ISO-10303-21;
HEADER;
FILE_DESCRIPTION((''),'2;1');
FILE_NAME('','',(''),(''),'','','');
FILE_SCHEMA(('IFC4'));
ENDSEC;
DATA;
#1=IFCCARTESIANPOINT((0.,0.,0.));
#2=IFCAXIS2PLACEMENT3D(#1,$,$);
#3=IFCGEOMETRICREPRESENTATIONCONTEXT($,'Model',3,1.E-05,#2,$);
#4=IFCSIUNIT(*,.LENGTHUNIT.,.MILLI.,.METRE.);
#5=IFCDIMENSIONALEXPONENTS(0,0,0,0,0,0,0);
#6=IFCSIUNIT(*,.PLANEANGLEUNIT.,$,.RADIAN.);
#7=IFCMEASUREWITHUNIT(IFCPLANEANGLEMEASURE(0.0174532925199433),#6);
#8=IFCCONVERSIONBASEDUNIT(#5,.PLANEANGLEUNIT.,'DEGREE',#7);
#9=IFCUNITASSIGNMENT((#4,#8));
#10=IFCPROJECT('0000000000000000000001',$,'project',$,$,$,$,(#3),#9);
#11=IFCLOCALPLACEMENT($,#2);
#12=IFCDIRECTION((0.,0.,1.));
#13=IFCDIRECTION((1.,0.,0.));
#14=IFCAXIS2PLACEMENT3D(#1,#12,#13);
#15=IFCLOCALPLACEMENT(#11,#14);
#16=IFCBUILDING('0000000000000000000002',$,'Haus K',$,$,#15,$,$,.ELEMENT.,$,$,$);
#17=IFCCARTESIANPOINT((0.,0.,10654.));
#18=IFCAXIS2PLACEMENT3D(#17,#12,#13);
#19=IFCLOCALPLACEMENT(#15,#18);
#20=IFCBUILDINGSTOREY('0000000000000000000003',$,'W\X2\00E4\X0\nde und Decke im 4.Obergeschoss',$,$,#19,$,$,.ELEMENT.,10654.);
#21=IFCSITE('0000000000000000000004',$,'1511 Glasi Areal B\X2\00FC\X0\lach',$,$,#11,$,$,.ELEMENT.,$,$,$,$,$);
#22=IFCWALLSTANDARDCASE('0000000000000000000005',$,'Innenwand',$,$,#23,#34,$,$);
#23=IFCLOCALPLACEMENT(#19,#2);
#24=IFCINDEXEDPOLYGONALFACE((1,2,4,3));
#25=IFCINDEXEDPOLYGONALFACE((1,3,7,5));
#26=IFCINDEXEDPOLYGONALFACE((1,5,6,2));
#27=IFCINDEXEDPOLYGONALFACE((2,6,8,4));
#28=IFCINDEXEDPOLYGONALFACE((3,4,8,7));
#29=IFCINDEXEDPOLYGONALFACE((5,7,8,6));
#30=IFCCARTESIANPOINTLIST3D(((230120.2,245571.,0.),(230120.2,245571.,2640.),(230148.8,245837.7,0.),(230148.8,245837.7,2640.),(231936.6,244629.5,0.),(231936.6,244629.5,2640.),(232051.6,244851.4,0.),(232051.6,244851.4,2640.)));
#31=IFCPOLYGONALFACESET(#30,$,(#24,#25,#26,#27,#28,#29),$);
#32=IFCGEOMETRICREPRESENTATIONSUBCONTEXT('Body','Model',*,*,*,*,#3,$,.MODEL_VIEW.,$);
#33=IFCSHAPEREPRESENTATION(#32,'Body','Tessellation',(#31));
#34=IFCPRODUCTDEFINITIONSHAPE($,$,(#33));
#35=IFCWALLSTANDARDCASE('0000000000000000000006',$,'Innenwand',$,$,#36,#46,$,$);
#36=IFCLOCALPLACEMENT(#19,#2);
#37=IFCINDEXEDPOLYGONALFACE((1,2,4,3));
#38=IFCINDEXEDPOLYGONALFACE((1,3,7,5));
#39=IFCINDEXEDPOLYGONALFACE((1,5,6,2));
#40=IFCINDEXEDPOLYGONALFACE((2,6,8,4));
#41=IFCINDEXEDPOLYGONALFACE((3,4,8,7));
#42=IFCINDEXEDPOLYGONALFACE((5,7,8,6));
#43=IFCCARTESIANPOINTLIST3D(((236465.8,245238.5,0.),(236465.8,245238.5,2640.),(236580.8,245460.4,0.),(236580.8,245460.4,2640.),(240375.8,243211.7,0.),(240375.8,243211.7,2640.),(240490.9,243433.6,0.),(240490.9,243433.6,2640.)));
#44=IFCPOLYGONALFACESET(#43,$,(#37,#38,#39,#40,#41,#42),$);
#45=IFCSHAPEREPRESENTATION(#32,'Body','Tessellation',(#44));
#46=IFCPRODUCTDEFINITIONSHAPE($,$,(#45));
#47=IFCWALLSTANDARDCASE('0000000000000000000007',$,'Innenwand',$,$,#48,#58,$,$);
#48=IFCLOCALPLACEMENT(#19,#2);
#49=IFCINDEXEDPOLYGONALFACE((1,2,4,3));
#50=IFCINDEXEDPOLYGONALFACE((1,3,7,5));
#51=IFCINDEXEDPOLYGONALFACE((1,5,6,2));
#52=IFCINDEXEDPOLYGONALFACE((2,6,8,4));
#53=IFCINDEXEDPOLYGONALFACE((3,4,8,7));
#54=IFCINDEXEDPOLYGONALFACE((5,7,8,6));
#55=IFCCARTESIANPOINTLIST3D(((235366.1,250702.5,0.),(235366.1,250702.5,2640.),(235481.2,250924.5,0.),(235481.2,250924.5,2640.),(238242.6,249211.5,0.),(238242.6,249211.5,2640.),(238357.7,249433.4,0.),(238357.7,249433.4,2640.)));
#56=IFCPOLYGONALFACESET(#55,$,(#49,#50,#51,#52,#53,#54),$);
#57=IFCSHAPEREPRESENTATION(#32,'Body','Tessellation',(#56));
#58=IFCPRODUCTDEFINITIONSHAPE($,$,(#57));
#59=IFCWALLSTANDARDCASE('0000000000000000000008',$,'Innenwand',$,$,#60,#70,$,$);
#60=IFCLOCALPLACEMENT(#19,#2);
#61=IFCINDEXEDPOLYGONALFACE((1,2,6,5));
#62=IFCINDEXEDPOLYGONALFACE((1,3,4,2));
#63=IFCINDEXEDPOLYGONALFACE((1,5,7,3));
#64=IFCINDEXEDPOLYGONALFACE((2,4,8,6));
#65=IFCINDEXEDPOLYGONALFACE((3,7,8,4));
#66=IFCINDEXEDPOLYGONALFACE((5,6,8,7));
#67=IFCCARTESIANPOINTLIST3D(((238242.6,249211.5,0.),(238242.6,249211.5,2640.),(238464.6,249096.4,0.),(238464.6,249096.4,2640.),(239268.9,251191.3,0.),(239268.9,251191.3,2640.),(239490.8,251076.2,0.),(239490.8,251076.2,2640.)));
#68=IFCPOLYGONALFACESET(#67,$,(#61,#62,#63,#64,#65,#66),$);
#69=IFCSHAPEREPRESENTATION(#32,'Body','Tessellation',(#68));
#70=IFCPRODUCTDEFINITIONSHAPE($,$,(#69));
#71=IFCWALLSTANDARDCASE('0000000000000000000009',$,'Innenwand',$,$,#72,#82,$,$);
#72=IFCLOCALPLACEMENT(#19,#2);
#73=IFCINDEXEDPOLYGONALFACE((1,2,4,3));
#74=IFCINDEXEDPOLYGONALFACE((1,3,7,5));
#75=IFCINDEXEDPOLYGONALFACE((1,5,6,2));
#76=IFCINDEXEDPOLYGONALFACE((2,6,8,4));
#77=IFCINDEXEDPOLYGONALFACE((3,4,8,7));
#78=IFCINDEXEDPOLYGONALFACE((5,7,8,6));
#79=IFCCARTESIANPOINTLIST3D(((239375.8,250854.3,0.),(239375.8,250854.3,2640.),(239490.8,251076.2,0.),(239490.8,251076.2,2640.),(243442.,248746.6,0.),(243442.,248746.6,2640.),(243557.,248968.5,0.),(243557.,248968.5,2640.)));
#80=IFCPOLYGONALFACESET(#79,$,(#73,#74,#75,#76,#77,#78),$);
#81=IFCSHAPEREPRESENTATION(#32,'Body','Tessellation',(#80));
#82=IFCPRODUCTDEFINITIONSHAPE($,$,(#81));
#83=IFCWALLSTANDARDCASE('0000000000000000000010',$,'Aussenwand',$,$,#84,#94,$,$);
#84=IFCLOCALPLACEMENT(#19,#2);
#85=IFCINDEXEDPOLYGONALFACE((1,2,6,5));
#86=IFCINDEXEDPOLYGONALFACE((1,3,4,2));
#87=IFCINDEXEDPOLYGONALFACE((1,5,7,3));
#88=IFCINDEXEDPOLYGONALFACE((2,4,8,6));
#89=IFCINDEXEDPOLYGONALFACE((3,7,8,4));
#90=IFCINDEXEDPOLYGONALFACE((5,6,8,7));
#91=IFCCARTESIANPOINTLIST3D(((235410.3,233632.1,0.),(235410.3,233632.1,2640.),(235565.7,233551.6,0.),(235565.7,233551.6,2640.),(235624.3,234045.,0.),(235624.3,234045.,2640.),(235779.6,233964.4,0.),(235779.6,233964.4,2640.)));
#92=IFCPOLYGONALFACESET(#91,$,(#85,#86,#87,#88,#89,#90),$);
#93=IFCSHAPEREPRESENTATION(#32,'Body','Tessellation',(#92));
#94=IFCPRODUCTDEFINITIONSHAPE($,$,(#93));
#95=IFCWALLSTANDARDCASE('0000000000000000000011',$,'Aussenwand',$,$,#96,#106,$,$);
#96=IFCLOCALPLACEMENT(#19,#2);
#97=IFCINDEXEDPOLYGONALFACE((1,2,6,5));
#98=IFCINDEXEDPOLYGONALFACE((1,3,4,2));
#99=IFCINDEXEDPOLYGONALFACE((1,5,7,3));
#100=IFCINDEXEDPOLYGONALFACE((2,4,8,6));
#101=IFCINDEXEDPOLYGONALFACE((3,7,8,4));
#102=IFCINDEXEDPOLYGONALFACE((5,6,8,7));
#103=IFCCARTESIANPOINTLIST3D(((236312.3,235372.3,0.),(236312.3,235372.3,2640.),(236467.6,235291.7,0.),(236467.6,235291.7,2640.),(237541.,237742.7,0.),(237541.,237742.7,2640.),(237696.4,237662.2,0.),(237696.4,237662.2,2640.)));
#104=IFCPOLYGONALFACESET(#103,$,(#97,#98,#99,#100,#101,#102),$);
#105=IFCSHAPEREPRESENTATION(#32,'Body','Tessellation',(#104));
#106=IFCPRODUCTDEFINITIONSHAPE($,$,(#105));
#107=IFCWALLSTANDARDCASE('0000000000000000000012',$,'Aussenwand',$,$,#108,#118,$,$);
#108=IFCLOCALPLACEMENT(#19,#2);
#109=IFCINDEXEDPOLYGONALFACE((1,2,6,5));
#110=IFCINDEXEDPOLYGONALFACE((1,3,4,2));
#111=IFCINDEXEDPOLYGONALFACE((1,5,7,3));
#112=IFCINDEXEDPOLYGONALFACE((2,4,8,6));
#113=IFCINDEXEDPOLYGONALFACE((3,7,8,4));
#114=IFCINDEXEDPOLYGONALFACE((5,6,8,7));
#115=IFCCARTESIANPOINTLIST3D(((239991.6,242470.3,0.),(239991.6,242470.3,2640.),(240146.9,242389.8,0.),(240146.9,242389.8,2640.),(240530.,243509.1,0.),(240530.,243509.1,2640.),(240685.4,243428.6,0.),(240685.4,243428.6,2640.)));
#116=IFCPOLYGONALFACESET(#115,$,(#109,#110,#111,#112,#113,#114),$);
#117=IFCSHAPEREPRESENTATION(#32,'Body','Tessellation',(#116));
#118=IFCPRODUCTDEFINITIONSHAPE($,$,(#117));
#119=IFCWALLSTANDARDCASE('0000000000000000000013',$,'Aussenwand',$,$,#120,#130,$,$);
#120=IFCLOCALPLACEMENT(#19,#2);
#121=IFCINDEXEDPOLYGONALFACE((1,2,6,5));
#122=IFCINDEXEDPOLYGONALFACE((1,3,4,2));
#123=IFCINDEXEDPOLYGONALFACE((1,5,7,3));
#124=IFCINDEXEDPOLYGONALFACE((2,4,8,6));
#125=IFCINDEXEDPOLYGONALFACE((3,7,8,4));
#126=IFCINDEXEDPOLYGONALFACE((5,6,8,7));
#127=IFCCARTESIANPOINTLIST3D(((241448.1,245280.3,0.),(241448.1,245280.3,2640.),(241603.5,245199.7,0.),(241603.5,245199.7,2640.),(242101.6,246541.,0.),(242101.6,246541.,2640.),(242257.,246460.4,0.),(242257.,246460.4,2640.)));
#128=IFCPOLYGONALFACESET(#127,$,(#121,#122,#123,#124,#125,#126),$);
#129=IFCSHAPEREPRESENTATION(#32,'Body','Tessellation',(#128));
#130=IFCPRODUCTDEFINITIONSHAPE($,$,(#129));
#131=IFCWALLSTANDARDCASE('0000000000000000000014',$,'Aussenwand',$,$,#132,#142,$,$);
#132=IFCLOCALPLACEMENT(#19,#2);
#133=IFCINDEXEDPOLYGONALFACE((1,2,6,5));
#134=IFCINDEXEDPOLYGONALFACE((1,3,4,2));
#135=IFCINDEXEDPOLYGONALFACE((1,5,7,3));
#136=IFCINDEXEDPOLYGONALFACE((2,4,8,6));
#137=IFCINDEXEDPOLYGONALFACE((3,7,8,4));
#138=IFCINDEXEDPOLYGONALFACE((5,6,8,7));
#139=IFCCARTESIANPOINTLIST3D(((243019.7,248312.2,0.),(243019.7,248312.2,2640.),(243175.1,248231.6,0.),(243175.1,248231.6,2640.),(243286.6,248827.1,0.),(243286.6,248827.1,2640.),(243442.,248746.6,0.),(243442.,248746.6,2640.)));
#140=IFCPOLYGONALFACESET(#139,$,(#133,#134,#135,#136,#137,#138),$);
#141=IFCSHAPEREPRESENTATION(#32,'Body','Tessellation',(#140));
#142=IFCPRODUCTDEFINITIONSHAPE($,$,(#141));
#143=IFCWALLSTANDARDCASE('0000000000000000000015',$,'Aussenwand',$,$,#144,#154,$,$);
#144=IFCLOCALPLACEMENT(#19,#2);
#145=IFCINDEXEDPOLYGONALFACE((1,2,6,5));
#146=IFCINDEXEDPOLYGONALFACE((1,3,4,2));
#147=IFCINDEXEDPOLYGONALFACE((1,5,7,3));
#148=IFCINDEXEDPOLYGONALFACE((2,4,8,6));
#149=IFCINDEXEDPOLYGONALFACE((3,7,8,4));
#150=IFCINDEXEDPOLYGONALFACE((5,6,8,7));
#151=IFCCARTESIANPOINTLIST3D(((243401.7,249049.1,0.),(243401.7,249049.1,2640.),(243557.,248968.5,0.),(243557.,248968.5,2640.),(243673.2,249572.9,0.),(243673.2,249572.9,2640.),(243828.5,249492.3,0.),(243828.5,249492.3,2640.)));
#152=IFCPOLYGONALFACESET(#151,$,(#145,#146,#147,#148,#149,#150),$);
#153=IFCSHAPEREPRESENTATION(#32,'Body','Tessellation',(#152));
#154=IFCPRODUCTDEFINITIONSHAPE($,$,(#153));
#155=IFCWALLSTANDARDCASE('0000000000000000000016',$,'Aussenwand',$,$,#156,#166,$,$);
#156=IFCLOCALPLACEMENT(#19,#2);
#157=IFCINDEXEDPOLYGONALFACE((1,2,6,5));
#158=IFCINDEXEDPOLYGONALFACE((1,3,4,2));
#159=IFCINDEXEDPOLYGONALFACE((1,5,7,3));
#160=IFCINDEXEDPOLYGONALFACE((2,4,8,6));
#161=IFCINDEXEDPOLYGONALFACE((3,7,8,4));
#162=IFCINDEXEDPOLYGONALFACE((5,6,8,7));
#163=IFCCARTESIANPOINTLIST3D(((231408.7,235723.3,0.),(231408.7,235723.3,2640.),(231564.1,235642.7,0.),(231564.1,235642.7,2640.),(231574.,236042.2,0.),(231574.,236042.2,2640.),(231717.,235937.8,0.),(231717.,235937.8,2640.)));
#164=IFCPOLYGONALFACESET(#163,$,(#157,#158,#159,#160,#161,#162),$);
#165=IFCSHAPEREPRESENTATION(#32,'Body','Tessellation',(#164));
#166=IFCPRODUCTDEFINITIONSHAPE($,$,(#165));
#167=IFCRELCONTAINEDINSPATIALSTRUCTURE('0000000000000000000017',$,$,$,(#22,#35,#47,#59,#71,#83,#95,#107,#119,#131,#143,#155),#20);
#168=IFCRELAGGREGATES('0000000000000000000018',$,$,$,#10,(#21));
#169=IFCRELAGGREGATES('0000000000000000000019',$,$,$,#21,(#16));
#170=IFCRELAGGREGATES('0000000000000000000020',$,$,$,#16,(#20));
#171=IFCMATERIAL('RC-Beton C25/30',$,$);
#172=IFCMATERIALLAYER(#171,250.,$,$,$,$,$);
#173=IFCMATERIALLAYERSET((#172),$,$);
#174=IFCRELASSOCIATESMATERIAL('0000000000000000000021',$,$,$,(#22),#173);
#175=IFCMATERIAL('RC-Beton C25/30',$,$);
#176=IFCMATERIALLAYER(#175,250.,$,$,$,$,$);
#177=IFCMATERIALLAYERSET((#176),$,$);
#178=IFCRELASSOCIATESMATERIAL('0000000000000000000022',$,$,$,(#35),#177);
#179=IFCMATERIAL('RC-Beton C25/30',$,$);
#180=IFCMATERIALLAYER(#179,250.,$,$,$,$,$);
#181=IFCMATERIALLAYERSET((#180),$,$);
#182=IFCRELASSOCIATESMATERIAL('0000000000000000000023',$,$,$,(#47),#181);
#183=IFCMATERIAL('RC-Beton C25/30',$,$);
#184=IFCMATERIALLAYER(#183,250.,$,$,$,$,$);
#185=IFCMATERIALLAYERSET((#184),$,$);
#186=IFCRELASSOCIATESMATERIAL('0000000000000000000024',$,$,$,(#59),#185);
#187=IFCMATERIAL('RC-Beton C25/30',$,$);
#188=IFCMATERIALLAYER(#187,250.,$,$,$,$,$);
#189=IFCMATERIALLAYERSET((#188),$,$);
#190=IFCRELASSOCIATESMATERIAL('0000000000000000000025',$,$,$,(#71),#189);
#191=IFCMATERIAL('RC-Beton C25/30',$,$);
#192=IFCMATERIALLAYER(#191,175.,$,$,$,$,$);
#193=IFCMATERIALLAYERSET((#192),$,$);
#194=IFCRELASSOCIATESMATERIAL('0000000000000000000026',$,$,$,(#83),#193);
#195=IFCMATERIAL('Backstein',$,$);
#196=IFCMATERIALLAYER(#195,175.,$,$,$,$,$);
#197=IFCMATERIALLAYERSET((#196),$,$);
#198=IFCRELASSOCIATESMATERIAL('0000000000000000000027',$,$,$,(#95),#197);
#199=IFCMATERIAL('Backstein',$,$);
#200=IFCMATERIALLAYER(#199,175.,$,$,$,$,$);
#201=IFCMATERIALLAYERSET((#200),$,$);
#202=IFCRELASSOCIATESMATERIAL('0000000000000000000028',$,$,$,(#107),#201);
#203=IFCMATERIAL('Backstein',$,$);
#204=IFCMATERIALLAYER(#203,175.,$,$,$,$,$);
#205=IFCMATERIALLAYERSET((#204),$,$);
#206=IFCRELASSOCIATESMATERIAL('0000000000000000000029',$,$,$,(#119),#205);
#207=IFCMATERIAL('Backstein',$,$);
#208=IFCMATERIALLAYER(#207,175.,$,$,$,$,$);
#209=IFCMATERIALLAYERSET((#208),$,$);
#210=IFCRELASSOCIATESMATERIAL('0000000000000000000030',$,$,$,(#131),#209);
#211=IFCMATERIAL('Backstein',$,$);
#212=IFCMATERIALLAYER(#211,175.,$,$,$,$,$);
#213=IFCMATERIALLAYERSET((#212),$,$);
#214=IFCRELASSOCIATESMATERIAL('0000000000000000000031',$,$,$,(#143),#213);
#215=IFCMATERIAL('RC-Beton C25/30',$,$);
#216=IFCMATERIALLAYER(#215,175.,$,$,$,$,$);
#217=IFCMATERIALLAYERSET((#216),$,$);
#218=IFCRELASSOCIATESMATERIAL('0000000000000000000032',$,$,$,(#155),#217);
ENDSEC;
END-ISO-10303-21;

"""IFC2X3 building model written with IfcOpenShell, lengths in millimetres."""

from ifc_helpers import new_model, entity, si_unit, converted_unit, frame, frame_2d, origin, origin_with_axes, place, context, subcontext, project, spatial, polyline, rectangle, outline, extrude, material, layer, layer_set, layer_usage, element, save


model = new_model("IFC2X3")

# Units and contexts
model_context = context("Model", 3, precision=1e-05, world=origin())
body_context = subcontext(model_context, "Body", "Model", "MODEL_VIEW")
ifc_project = project(units=[si_unit("LENGTHUNIT", "METRE", prefix="MILLI"), converted_unit("PLANEANGLEUNIT", "DEGREE", entity("IfcPlaneAngleMeasure", 0.0174532925199433), si_unit("PLANEANGLEUNIT", "RADIAN"), dimensions=[0, 0, 0, 0, 0, 0, 0])], contexts=[model_context])

# Site, building, storey
site_placement = place(None, origin())
site = spatial("IfcSite", under=ifc_project, at=site_placement, Name="1511 Glasi Areal Bülach", CompositionType="ELEMENT")
building_placement = place(site_placement, origin_with_axes())
building = spatial("IfcBuilding", under=site, at=building_placement, Name="Haus K", CompositionType="ELEMENT")
storey_placement = place(building_placement, frame((0.0, 0.0, 10654.0), z_axis=(0.0, 0.0, 1.0), x_axis=(1.0, 0.0, 0.0)))
storey = spatial("IfcBuildingStorey", under=building, at=storey_placement, Name="Wände und Decke im 4.Obergeschoss", CompositionType="ELEMENT", Elevation=10654.0)

# Walls
ifc_material_1 = material(Name="RC-Beton C25/30")
ifc_layer_1 = layer(ifc_material_1, 250.0)
ifc_layer_set_1 = layer_set([ifc_layer_1])
ifc_layer_usage_1 = layer_usage(ifc_layer_set_1, "AXIS2", "POSITIVE", 0.0)
wall_1_placement = place(storey_placement, frame((232051.6, 244851.4, 0.0), z_axis=(0.0, 0.0, 1.0), x_axis=(-0.887815, 0.4602, 0.0)))
element("IfcWallStandardCase", 1, at=wall_1_placement, inside=storey, material=ifc_layer_usage_1, Name="Innenwand", context=body_context, shape_type="SweptSolid", body=[
    extrude(outline(polyline([(0.0, 0.0), (2143.2, 0.0), (2045.9, 250.0), (0.0, 250.0), (0.0, 0.0)])), origin_with_axes(), (0.0, 0.0, 1.0), 2640.0),
])
ifc_material_2 = material(Name="RC-Beton C25/30")
ifc_layer_2 = layer(ifc_material_2, 250.0)
ifc_layer_set_2 = layer_set([ifc_layer_2])
ifc_layer_usage_2 = layer_usage(ifc_layer_set_2, "AXIS2", "POSITIVE", 0.0)
wall_2_placement = place(storey_placement, frame((240490.9, 243433.6, 0.0), z_axis=(0.0, 0.0, 1.0), x_axis=(-0.887815, 0.4602, 0.0)))
element("IfcWallStandardCase", 2, at=wall_2_placement, inside=storey, material=ifc_layer_usage_2, Name="Innenwand", context=body_context, shape_type="SweptSolid", body=[
    extrude(rectangle(XDim=4404.2, YDim=250.0, at=frame_2d((2202.1, 125.0), x_axis=(1.0, 0.0))), origin_with_axes(), (0.0, 0.0, 1.0), 2640.0),
])
ifc_material_3 = material(Name="RC-Beton C25/30")
ifc_layer_3 = layer(ifc_material_3, 250.0)
ifc_layer_set_3 = layer_set([ifc_layer_3])
ifc_layer_usage_3 = layer_usage(ifc_layer_set_3, "AXIS2", "POSITIVE", 0.0)
wall_3_placement = place(storey_placement, frame((238357.7, 249433.4, 0.0), z_axis=(0.0, 0.0, 1.0), x_axis=(-0.887815, 0.4602, 0.0)))
element("IfcWallStandardCase", 3, at=wall_3_placement, inside=storey, material=ifc_layer_usage_3, Name="Innenwand", context=body_context, shape_type="SweptSolid", body=[
    extrude(rectangle(XDim=3240.0, YDim=250.0, at=frame_2d((1620.0, 125.0), x_axis=(1.0, 0.0))), origin_with_axes(), (0.0, 0.0, 1.0), 2640.0),
])
ifc_material_4 = material(Name="RC-Beton C25/30")
ifc_layer_4 = layer(ifc_material_4, 250.0)
ifc_layer_set_4 = layer_set([ifc_layer_4])
ifc_layer_usage_4 = layer_usage(ifc_layer_set_4, "AXIS2", "POSITIVE", 0.0)
wall_4_placement = place(storey_placement, frame((238464.6, 249096.4, 0.0), z_axis=(0.0, 0.0, 1.0), x_axis=(0.4602, 0.887815, 0.0)))
element("IfcWallStandardCase", 4, at=wall_4_placement, inside=storey, material=ifc_layer_usage_4, Name="Innenwand", context=body_context, shape_type="SweptSolid", body=[
    extrude(rectangle(XDim=2230.0, YDim=250.0, at=frame_2d((1115.0, 125.0), x_axis=(1.0, 0.0))), origin_with_axes(), (0.0, 0.0, 1.0), 2640.0),
])
ifc_material_5 = material(Name="RC-Beton C25/30")
ifc_layer_5 = layer(ifc_material_5, 250.0)
ifc_layer_set_5 = layer_set([ifc_layer_5])
ifc_layer_usage_5 = layer_usage(ifc_layer_set_5, "AXIS2", "POSITIVE", 0.0)
wall_5_placement = place(storey_placement, frame((239375.8, 250854.3, 0.0), z_axis=(0.0, 0.0, 1.0), x_axis=(0.887815, -0.4602, 0.0)))
element("IfcWallStandardCase", 5, at=wall_5_placement, inside=storey, material=ifc_layer_usage_5, Name="Innenwand", context=body_context, shape_type="SweptSolid", body=[
    extrude(rectangle(XDim=4580.0, YDim=250.0, at=frame_2d((2290.0, 125.0), x_axis=(1.0, 0.0))), origin_with_axes(), (0.0, 0.0, 1.0), 2640.0),
])
ifc_material_6 = material(Name="RC-Beton C25/30")
ifc_layer_6 = layer(ifc_material_6, 175.0)
ifc_layer_set_6 = layer_set([ifc_layer_6])
ifc_layer_usage_6 = layer_usage(ifc_layer_set_6, "AXIS2", "POSITIVE", 0.0)
wall_6_placement = place(storey_placement, frame((235565.7, 233551.6, 0.0), z_axis=(0.0, 0.0, 1.0), x_axis=(0.4602, 0.887815, 0.0)))
element("IfcWallStandardCase", 6, at=wall_6_placement, inside=storey, material=ifc_layer_usage_6, Name="Aussenwand", context=body_context, shape_type="SweptSolid", body=[
    extrude(rectangle(XDim=465.0, YDim=175.0, at=frame_2d((232.5, 87.5), x_axis=(1.0, 0.0))), origin_with_axes(), (0.0, 0.0, 1.0), 2640.0),
])
ifc_material_7 = material(Name="Backstein")
ifc_layer_7 = layer(ifc_material_7, 175.0)
ifc_layer_set_7 = layer_set([ifc_layer_7])
ifc_layer_usage_7 = layer_usage(ifc_layer_set_7, "AXIS2", "POSITIVE", 0.0)
wall_7_placement = place(storey_placement, frame((236467.6, 235291.7, 0.0), z_axis=(0.0, 0.0, 1.0), x_axis=(0.4602, 0.887815, 0.0)))
element("IfcWallStandardCase", 7, at=wall_7_placement, inside=storey, material=ifc_layer_usage_7, Name="Aussenwand", context=body_context, shape_type="SweptSolid", body=[
    extrude(rectangle(XDim=2670.0, YDim=175.0, at=frame_2d((1335.0, 87.5), x_axis=(1.0, 0.0))), origin_with_axes(), (0.0, 0.0, 1.0), 2640.0),
])
ifc_material_8 = material(Name="Backstein")
ifc_layer_8 = layer(ifc_material_8, 175.0)
ifc_layer_set_8 = layer_set([ifc_layer_8])
ifc_layer_usage_8 = layer_usage(ifc_layer_set_8, "AXIS2", "POSITIVE", 0.0)
wall_8_placement = place(storey_placement, frame((240146.9, 242389.8, 0.0), z_axis=(0.0, 0.0, 1.0), x_axis=(0.4602, 0.887815, 0.0)))
element("IfcWallStandardCase", 8, at=wall_8_placement, inside=storey, material=ifc_layer_usage_8, Name="Aussenwand", context=body_context, shape_type="SweptSolid", body=[
    extrude(rectangle(XDim=1170.0, YDim=175.0, at=frame_2d((585.0, 87.5), x_axis=(1.0, 0.0))), origin_with_axes(), (0.0, 0.0, 1.0), 2640.0),
])
ifc_material_9 = material(Name="Backstein")
ifc_layer_9 = layer(ifc_material_9, 175.0)
ifc_layer_set_9 = layer_set([ifc_layer_9])
ifc_layer_usage_9 = layer_usage(ifc_layer_set_9, "AXIS2", "POSITIVE", 0.0)
wall_9_placement = place(storey_placement, frame((241603.5, 245199.7, 0.0), z_axis=(0.0, 0.0, 1.0), x_axis=(0.4602, 0.887815, 0.0)))
element("IfcWallStandardCase", 9, at=wall_9_placement, inside=storey, material=ifc_layer_usage_9, Name="Aussenwand", context=body_context, shape_type="SweptSolid", body=[
    extrude(rectangle(XDim=1420.0, YDim=175.0, at=frame_2d((710.0, 87.5), x_axis=(1.0, 0.0))), origin_with_axes(), (0.0, 0.0, 1.0), 2640.0),
])
ifc_material_10 = material(Name="Backstein")
ifc_layer_10 = layer(ifc_material_10, 175.0)
ifc_layer_set_10 = layer_set([ifc_layer_10])
ifc_layer_usage_10 = layer_usage(ifc_layer_set_10, "AXIS2", "POSITIVE", 0.0)
wall_10_placement = place(storey_placement, frame((243175.1, 248231.6, 0.0), z_axis=(0.0, 0.0, 1.0), x_axis=(0.4602, 0.887815, 0.0)))
element("IfcWallStandardCase", 10, at=wall_10_placement, inside=storey, material=ifc_layer_usage_10, Name="Aussenwand", context=body_context, shape_type="SweptSolid", body=[
    extrude(rectangle(XDim=580.0, YDim=175.0, at=frame_2d((290.0, 87.5), x_axis=(1.0, 0.0))), origin_with_axes(), (0.0, 0.0, 1.0), 2640.0),
])
ifc_material_11 = material(Name="Backstein")
ifc_layer_11 = layer(ifc_material_11, 175.0)
ifc_layer_set_11 = layer_set([ifc_layer_11])
ifc_layer_usage_11 = layer_usage(ifc_layer_set_11, "AXIS2", "POSITIVE", 0.0)
wall_11_placement = place(storey_placement, frame((243557.0, 248968.5, 0.0), z_axis=(0.0, 0.0, 1.0), x_axis=(0.4602, 0.887815, 0.0)))
element("IfcWallStandardCase", 11, at=wall_11_placement, inside=storey, material=ifc_layer_usage_11, Name="Aussenwand", context=body_context, shape_type="SweptSolid", body=[
    extrude(rectangle(XDim=590.0, YDim=175.0, at=frame_2d((295.0, 87.5), x_axis=(1.0, 0.0))), origin_with_axes(), (0.0, 0.0, 1.0), 2640.0),
])
ifc_material_12 = material(Name="RC-Beton C25/30")
ifc_layer_12 = layer(ifc_material_12, 175.0)
ifc_layer_set_12 = layer_set([ifc_layer_12])
ifc_layer_usage_12 = layer_usage(ifc_layer_set_12, "AXIS2", "POSITIVE", 0.0)
wall_12_placement = place(storey_placement, frame((231574.0, 236042.2, 0.0), z_axis=(0.0, 0.0, 1.0), x_axis=(-0.4602, -0.887815, 0.0)))
element("IfcWallStandardCase", 12, at=wall_12_placement, inside=storey, material=ifc_layer_usage_12, Name="Aussenwand", context=body_context, shape_type="SweptSolid", body=[
    extrude(outline(polyline([(0.0, 0.0), (359.2, 0.0), (359.2, 175.0), (26.9, 175.0), (0.0, 0.0)])), origin_with_axes(), (0.0, 0.0, 1.0), 2640.0),
])

save(model, "model.ifc")
